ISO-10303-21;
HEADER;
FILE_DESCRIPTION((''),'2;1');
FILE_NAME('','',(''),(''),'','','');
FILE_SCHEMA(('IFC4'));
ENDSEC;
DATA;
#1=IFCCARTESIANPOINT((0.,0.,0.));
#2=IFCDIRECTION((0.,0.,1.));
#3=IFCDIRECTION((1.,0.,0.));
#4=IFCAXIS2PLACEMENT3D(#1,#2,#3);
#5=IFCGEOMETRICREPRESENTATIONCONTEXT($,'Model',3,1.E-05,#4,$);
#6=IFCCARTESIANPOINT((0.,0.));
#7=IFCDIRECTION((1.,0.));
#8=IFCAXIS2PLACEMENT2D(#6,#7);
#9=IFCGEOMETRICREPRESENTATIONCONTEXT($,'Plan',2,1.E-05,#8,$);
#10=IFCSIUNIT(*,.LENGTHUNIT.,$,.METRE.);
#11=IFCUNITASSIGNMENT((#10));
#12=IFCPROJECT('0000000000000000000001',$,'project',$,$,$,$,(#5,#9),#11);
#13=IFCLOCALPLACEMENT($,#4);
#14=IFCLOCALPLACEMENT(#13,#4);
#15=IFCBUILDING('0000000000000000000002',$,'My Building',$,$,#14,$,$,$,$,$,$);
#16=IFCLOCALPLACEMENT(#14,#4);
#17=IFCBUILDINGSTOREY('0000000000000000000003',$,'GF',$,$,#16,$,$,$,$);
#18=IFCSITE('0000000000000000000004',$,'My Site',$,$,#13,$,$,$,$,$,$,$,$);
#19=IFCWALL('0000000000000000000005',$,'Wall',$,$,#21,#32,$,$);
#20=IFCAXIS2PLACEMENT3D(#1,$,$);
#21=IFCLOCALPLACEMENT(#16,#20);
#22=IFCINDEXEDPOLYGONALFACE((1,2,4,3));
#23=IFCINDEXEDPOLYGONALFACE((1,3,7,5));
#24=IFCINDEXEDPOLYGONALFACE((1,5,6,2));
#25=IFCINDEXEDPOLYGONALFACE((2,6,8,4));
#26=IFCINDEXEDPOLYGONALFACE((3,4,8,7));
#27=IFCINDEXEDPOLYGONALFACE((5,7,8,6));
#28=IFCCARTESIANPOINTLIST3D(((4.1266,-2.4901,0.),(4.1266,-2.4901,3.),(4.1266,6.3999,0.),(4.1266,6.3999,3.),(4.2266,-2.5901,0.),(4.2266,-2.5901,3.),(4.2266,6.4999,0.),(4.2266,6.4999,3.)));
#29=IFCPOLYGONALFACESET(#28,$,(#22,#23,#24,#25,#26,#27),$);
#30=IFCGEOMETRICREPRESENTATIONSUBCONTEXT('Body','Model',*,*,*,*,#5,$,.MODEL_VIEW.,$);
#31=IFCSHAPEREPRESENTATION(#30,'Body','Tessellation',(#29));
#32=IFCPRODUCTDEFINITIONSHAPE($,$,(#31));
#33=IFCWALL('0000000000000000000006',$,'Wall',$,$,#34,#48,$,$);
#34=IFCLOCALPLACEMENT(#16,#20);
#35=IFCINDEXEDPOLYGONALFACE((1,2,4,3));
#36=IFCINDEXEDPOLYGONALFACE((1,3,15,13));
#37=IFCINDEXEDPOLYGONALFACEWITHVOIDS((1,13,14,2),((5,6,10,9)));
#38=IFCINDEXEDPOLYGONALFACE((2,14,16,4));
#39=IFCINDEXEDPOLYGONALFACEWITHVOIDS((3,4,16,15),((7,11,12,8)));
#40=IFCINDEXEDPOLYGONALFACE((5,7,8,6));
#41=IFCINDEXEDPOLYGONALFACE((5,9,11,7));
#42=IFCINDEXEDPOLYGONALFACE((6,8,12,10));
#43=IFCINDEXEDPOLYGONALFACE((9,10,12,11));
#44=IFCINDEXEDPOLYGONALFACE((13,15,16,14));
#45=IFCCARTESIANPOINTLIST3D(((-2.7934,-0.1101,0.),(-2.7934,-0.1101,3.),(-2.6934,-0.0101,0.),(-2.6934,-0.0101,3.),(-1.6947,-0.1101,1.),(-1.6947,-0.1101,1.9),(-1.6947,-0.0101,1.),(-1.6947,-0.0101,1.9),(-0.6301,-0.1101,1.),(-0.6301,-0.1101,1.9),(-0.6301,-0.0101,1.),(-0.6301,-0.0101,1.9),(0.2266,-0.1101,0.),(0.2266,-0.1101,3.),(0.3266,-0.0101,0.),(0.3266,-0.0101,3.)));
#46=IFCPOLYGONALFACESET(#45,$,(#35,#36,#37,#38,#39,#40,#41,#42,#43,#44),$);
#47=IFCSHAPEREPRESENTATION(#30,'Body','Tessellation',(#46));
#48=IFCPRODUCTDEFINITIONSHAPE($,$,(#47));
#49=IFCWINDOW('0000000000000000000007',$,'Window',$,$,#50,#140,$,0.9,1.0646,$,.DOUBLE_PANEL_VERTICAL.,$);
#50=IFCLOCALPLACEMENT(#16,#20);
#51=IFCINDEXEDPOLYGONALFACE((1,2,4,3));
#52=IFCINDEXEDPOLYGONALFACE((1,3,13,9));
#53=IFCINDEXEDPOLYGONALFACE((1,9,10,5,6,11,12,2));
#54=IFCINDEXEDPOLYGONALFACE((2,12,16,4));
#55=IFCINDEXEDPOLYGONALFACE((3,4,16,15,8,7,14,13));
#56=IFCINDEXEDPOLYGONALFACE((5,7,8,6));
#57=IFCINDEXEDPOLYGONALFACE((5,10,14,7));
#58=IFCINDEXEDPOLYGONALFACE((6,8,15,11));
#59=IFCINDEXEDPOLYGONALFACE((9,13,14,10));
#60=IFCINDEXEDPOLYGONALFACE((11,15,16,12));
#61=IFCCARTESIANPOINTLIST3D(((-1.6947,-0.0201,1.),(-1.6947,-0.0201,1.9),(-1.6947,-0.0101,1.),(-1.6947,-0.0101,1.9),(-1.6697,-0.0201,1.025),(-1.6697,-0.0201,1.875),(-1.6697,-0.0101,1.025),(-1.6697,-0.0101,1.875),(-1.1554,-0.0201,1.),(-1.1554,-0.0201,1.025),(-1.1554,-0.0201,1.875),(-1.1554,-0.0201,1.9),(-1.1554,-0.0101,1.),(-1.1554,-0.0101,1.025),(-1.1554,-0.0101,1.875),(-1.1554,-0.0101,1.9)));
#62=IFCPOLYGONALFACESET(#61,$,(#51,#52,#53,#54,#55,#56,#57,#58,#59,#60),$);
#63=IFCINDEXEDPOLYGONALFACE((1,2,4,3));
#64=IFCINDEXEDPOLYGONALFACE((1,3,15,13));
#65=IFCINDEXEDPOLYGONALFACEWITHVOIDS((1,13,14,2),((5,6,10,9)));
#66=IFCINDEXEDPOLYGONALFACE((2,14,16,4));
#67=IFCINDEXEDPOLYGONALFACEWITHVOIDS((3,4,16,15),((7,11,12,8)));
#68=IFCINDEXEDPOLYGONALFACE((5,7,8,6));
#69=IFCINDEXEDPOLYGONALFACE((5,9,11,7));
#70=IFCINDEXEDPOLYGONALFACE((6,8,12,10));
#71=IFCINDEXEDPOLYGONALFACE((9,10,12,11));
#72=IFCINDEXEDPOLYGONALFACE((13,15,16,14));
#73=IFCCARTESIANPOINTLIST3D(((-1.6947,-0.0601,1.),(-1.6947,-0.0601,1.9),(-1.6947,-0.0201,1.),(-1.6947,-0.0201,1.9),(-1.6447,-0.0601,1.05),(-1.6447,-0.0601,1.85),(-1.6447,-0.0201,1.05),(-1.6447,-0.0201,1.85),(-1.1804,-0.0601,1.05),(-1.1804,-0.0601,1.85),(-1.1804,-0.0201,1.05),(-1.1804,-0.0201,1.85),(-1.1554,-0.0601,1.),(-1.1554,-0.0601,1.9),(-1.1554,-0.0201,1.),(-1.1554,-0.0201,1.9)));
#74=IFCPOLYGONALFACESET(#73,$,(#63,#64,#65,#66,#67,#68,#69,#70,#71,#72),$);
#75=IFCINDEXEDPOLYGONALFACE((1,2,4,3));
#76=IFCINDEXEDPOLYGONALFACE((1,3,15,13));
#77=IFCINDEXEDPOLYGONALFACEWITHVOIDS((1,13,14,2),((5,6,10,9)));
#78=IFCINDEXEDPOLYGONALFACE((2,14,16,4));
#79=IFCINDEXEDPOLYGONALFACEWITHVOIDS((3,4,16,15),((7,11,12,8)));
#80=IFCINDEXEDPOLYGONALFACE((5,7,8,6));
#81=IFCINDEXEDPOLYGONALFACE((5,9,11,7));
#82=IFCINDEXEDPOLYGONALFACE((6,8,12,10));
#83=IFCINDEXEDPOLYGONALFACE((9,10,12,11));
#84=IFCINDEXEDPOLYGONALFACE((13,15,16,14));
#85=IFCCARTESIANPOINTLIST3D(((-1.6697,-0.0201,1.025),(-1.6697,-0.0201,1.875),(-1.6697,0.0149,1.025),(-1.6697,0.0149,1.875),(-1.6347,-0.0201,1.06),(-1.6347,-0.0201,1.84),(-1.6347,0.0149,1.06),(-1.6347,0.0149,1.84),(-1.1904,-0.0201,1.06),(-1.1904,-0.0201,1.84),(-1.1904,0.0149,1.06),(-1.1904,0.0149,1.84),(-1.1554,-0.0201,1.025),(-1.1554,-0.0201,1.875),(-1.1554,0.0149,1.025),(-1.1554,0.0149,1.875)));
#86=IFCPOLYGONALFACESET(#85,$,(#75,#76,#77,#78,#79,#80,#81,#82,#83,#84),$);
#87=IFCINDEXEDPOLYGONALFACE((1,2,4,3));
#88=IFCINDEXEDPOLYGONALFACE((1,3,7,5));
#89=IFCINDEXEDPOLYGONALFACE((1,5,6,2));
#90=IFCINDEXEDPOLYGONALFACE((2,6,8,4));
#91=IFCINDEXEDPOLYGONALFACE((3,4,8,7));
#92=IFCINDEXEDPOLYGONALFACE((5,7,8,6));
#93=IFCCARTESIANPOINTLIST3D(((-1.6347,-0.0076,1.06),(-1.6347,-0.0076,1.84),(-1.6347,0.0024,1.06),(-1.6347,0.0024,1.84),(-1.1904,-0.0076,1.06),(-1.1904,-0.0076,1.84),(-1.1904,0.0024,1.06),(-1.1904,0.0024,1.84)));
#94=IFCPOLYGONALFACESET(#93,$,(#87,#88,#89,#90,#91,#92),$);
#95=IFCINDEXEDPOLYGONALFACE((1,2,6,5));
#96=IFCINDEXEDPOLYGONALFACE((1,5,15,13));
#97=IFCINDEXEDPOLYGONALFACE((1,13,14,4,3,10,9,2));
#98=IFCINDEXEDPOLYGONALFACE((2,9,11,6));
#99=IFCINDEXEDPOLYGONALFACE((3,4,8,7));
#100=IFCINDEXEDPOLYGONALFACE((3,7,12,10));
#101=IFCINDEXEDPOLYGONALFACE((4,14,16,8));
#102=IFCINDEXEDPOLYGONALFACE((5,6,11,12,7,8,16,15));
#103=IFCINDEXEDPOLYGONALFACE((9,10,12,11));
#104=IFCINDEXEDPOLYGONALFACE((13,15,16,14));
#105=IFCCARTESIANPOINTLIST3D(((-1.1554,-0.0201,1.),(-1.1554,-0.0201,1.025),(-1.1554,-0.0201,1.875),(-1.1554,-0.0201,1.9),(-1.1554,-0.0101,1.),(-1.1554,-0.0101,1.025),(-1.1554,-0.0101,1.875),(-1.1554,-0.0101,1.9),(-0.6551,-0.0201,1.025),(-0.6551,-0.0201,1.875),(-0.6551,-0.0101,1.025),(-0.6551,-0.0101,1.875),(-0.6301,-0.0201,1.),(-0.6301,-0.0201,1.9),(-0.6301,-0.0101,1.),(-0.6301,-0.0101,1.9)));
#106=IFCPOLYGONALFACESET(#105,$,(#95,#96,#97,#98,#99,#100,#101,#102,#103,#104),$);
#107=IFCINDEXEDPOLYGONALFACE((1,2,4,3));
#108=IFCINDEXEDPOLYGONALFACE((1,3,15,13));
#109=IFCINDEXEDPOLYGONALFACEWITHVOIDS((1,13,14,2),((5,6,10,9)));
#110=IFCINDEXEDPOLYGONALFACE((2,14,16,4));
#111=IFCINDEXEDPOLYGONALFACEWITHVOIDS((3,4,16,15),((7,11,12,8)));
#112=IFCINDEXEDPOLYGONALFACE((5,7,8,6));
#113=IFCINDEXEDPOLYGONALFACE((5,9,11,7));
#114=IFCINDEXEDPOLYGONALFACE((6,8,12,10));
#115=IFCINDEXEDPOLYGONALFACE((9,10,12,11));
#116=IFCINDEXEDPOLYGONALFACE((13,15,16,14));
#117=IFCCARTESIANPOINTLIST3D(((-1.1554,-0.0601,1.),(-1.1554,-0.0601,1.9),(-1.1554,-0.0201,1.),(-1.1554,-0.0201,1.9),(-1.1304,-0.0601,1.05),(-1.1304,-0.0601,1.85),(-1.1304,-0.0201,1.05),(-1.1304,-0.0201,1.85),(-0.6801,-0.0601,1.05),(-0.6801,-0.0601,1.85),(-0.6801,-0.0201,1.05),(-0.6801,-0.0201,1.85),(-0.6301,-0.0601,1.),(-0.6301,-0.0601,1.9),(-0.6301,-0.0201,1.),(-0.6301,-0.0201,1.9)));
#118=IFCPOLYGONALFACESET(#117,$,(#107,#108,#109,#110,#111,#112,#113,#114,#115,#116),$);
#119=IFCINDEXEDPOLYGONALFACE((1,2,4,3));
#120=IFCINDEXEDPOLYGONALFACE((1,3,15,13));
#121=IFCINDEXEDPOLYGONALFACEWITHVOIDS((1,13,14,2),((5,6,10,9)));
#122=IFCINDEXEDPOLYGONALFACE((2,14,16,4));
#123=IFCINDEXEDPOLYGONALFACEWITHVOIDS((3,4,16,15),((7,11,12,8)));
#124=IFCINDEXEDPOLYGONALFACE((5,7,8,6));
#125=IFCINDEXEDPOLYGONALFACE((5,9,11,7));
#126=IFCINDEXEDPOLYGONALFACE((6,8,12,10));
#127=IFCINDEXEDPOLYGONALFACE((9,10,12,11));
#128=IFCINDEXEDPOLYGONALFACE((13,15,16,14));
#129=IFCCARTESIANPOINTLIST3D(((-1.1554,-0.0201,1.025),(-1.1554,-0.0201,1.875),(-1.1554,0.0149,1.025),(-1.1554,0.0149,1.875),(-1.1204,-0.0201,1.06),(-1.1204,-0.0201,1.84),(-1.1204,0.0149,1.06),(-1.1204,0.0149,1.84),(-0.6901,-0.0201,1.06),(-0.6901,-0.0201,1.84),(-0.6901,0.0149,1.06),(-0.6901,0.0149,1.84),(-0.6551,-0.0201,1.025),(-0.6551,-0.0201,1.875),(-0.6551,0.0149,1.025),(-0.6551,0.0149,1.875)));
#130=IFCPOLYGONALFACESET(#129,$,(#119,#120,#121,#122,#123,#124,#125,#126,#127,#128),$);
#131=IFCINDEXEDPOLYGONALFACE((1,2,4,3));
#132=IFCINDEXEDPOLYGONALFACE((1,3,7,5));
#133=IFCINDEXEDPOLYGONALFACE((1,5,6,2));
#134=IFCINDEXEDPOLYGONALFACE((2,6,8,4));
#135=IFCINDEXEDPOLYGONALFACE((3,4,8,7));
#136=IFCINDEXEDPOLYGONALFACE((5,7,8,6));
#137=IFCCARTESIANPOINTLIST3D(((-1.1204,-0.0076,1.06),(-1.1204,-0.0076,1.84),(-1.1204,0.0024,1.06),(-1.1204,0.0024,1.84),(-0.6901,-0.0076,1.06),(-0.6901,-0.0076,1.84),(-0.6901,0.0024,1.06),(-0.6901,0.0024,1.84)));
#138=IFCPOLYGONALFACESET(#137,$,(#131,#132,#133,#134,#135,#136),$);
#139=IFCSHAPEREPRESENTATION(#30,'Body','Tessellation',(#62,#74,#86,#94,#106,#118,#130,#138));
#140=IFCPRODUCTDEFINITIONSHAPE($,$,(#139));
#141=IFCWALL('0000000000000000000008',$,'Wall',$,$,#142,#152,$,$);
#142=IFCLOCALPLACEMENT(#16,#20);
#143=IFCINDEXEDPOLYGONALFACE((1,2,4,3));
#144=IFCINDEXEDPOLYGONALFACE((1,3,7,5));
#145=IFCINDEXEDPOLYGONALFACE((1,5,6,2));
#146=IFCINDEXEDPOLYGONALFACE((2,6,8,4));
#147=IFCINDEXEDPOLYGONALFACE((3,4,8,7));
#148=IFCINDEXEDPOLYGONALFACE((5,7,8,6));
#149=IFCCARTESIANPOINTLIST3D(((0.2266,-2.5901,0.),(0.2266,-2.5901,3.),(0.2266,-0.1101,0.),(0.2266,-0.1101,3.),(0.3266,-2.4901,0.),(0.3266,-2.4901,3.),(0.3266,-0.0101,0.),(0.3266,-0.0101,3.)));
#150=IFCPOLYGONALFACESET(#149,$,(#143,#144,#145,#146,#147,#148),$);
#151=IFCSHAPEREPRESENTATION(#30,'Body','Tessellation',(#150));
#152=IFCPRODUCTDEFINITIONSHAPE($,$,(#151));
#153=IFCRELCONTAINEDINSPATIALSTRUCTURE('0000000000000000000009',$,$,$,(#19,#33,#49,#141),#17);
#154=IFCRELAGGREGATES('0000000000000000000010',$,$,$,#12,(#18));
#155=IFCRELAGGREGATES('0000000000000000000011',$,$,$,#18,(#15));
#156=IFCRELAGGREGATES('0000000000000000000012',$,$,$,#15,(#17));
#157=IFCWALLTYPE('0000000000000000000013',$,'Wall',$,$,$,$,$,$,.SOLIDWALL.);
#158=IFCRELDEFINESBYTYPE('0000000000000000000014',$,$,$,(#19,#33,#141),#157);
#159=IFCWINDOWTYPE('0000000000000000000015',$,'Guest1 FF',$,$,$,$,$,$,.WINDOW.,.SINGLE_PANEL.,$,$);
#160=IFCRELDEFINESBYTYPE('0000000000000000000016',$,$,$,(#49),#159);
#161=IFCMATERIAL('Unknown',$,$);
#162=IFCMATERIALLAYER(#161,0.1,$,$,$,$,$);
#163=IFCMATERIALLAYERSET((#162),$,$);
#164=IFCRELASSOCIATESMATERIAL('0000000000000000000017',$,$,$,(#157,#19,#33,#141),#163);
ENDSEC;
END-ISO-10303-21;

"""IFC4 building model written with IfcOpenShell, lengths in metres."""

from ifc_helpers import new_model, entity, si_unit, frame, origin_with_axes, origin_2d_with_axis, place, context, subcontext, project, spatial, line, indexed_curve, outline, extrude, shape, source, transform, mapped, material, layer, layer_set, layer_usage, type_object, type_shapes, element, fill, save


model = new_model("IFC4")

# Units and contexts
model_context = context("Model", 3, precision=1e-05, world=origin_with_axes())
plan_context = context("Plan", 2, precision=1e-05, world=origin_2d_with_axis())
body_context_1 = subcontext(model_context, "Body", "Model", "MODEL_VIEW")
body_context_2 = subcontext(plan_context, "Body", "Plan", "PLAN_VIEW")
ifc_project = project(units=[si_unit("LENGTHUNIT", "METRE")], contexts=[model_context, plan_context])

# Site, building, storey
site_placement = place(None, origin_with_axes())
site = spatial("IfcSite", under=ifc_project, at=site_placement, Name="My Site")
building_placement = place(site_placement, origin_with_axes())
building = spatial("IfcBuilding", under=site, at=building_placement, Name="My Building")
storey_placement = place(building_placement, origin_with_axes())
storey = spatial("IfcBuildingStorey", under=building, at=storey_placement, Name="GF")

# Shared definitions
ifc_material = material(Name="Unknown")

# Shared definitions
ifc_layer_1 = layer(ifc_material, 0.1)
ifc_layer_set_1 = layer_set([ifc_layer_1])
wall_type = type_object("IfcWallType", Name="Wall", PredefinedType="SOLIDWALL", material=ifc_layer_set_1)

# Wall
ifc_layer_usage_1 = layer_usage(ifc_layer_set_1, "AXIS2", "POSITIVE", 0.0)
wall_1_placement = place(storey_placement, frame((4.2266, -2.5901, 0.0), z_axis=(0.0, 0.0, 1.0), x_axis=(0.0, 1.0, 0.0)))
element("IfcWall", 1, at=wall_1_placement, inside=storey, type_object=wall_type, material=ifc_layer_usage_1, Name="Wall", context=body_context_1, shape_type="SweptSolid", body=[
    extrude(outline(indexed_curve([(0.0, 0.0), (0.1, 0.1), (8.99, 0.1), (9.09, 0.0)], segments=[line(1, 2, 3, 4, 1)])), origin_with_axes(), (0.0, 0.0, 1.0), 3.0),
])

# Wall, opening, window
ifc_layer_usage_2 = layer_usage(ifc_layer_set_1, "AXIS2", "POSITIVE", 0.0)
wall_2_placement = place(storey_placement, frame((-2.7934, -0.1101, 0.0), z_axis=(0.0, 0.0, 1.0), x_axis=(1.0, 0.0, 0.0)))
wall_2 = element("IfcWall", 2, at=wall_2_placement, inside=storey, type_object=wall_type, material=ifc_layer_usage_2, Name="Wall", context=body_context_1, shape_type="SweptSolid", body=[
    extrude(outline(indexed_curve([(0.0, 0.0), (0.1, 0.1), (3.12, 0.1), (3.02, 0.0)], segments=[line(1, 2, 3, 4, 1)])), origin_with_axes(), (0.0, 0.0, 1.0), 3.0),
])
shared_shape_1 = source(origin_with_axes(), body_context_1, "Body", "SweptSolid", [
    extrude(outline(indexed_curve([(0.0, 0.0), (1.0646, 0.0), (1.0646, 0.9), (0.0, 0.9)], segments=[line(1, 2, 3, 4, 1)])), frame((0.0, -0.6, 0.0), z_axis=(0.0, -1.0, 0.0), x_axis=(1.0, 0.0, 0.0)), (0.0, 0.0, -1.0), 1.2),
])
opening_1_placement = place(wall_2_placement, frame((1.0987, 0.0, 1.0), z_axis=(0.0, 0.0, 1.0), x_axis=(1.0, 0.0, 0.0)))
opening_1 = element("IfcOpeningElement", 3, at=opening_1_placement, cuts=wall_2, PredefinedType="OPENING", context=body_context_1, shape_type="MappedRepresentation", body=[
    mapped(shared_shape_1, transform((0.0, 0.0, 0.0), x_axis=(1.0, 0.0, 0.0), y_axis=(0.0, 1.0, 0.0), z_axis=(0.0, 0.0, 1.0), scale=1.0)),
])
window_type_1 = type_object("IfcWindowType", Name="Guest1 FF", PartitioningType="SINGLE_PANEL", PredefinedType="WINDOW")
shared_shape_2 = source(origin_with_axes(), body_context_1, "Body", "SweptSolid", [
    extrude(outline(indexed_curve([(0.5393, 0.0), (0.0, 0.0), (0.0, 0.9), (0.5393, 0.9), (0.5393, 0.875), (0.025, 0.875), (0.025, 0.025), (0.5393, 0.025)], segments=[line(1, 2, 3, 4, 5, 6, 7, 8, 1)])), frame((0.0, 0.09, 0.0), z_axis=(0.0, -1.0, 0.0), x_axis=(1.0, 0.0, 0.0)), (0.0, 0.0, -1.0), 0.01),
    extrude(outline(indexed_curve([(0.0, 0.0), (0.5393, 0.0), (0.5393, 0.9), (0.0, 0.9)], segments=[line(1, 2, 3, 4, 1)]), holes=[indexed_curve([(0.05, 0.05), (0.5143, 0.05), (0.5143, 0.85), (0.05, 0.85)], segments=[line(1, 2, 3, 4, 1)])]), frame((0.0, 0.05, 0.0), z_axis=(0.0, -1.0, 0.0), x_axis=(1.0, 0.0, 0.0)), (0.0, 0.0, -1.0), 0.04),
    extrude(outline(indexed_curve([(0.0, 0.0), (0.5143, 0.0), (0.5143, 0.85), (0.0, 0.85)], segments=[line(1, 2, 3, 4, 1)]), holes=[indexed_curve([(0.035, 0.035), (0.4793, 0.035), (0.4793, 0.815), (0.035, 0.815)], segments=[line(1, 2, 3, 4, 1)])]), frame((0.025, 0.09, 0.025), z_axis=(0.0, -1.0, 0.0), x_axis=(1.0, 0.0, 0.0)), (0.0, 0.0, -1.0), 0.035),
    extrude(outline(indexed_curve([(0.035, 0.035), (0.4793, 0.035), (0.4793, 0.815), (0.035, 0.815)], segments=[line(1, 2, 3, 4, 1)])), frame((0.025, 0.1025, 0.025), z_axis=(0.0, -1.0, 0.0), x_axis=(1.0, 0.0, 0.0)), (0.0, 0.0, -1.0), 0.01),
    extrude(outline(indexed_curve([(0.0, 0.9), (0.5253, 0.9), (0.5253, 0.0), (0.0, 0.0), (0.0, 0.025), (0.5003, 0.025), (0.5003, 0.875), (0.0, 0.875)], segments=[line(1, 2, 3, 4, 5, 6, 7, 8, 1)])), frame((0.5393, 0.09, 0.0), z_axis=(0.0, -1.0, 0.0), x_axis=(1.0, 0.0, 0.0)), (0.0, 0.0, -1.0), 0.01),
    extrude(outline(indexed_curve([(0.0, 0.0), (0.5253, 0.0), (0.5253, 0.9), (0.0, 0.9)], segments=[line(1, 2, 3, 4, 1)]), holes=[indexed_curve([(0.025, 0.05), (0.4753, 0.05), (0.4753, 0.85), (0.025, 0.85)], segments=[line(1, 2, 3, 4, 1)])]), frame((0.5393, 0.05, 0.0), z_axis=(0.0, -1.0, 0.0), x_axis=(1.0, 0.0, 0.0)), (0.0, 0.0, -1.0), 0.04),
    extrude(outline(indexed_curve([(0.0, 0.0), (0.5003, 0.0), (0.5003, 0.85), (0.0, 0.85)], segments=[line(1, 2, 3, 4, 1)]), holes=[indexed_curve([(0.035, 0.035), (0.4653, 0.035), (0.4653, 0.815), (0.035, 0.815)], segments=[line(1, 2, 3, 4, 1)])]), frame((0.5393, 0.09, 0.025), z_axis=(0.0, -1.0, 0.0), x_axis=(1.0, 0.0, 0.0)), (0.0, 0.0, -1.0), 0.035),
    extrude(outline(indexed_curve([(0.035, 0.035), (0.4653, 0.035), (0.4653, 0.815), (0.035, 0.815)], segments=[line(1, 2, 3, 4, 1)])), frame((0.5393, 0.1025, 0.025), z_axis=(0.0, -1.0, 0.0), x_axis=(1.0, 0.0, 0.0)), (0.0, 0.0, -1.0), 0.01),
])
shared_shape_3 = source(origin_with_axes(), body_context_2, "Body", "Curve2D", [
    entity("IfcIndexedPolyCurve", entity("IfcCartesianPointList2D", [[0.05, 0.05], [0.5143, 0.05]])),
    entity("IfcIndexedPolyCurve", entity("IfcCartesianPointList2D", [[0.0, 0.1], [0.025, 0.1], [0.025, 0.09], [0.05, 0.09], [0.05, 0.05], [0.0, 0.05]]), [entity("IfcLineIndex", [1, 2, 3, 4, 5, 6, 1])]),
    entity("IfcIndexedPolyCurve", entity("IfcCartesianPointList2D", [[0.5393, 0.1], [0.5393, 0.1], [0.5393, 0.09], [0.5143, 0.09], [0.5143, 0.05], [0.5393, 0.05]])),
    entity("IfcIndexedPolyCurve", entity("IfcCartesianPointList2D", [[0.025, 0.09], [0.06, 0.09], [0.06, 0.125], [0.025, 0.125]]), [entity("IfcLineIndex", [1, 2, 3, 4, 1])]),
    entity("IfcIndexedPolyCurve", entity("IfcCartesianPointList2D", [[0.5393, 0.09], [0.5043, 0.09], [0.5043, 0.125], [0.5393, 0.125]]), [entity("IfcLineIndex", [1, 2, 3, 4, 1])]),
    entity("IfcIndexedPolyCurve", entity("IfcCartesianPointList2D", [[0.06, 0.09], [0.5043, 0.09]])),
    entity("IfcIndexedPolyCurve", entity("IfcCartesianPointList2D", [[0.06, 0.125], [0.5043, 0.125]])),
    entity("IfcIndexedPolyCurve", entity("IfcCartesianPointList2D", [[0.06, 0.1075], [0.5043, 0.1075]])),
    entity("IfcIndexedPolyCurve", entity("IfcCartesianPointList2D", [[0.5643, 0.05], [1.0146, 0.05]])),
    entity("IfcIndexedPolyCurve", entity("IfcCartesianPointList2D", [[0.5393, 0.1], [0.5393, 0.1], [0.5393, 0.09], [0.5643, 0.09], [0.5643, 0.05], [0.5393, 0.05]])),
    entity("IfcIndexedPolyCurve", entity("IfcCartesianPointList2D", [[1.0646, 0.1], [1.0396, 0.1], [1.0396, 0.09], [1.0146, 0.09], [1.0146, 0.05], [1.0646, 0.05]]), [entity("IfcLineIndex", [1, 2, 3, 4, 5, 6, 1])]),
    entity("IfcIndexedPolyCurve", entity("IfcCartesianPointList2D", [[0.5393, 0.09], [0.5743, 0.09], [0.5743, 0.125], [0.5393, 0.125]]), [entity("IfcLineIndex", [1, 2, 3, 4, 1])]),
    entity("IfcIndexedPolyCurve", entity("IfcCartesianPointList2D", [[1.0396, 0.09], [1.0046, 0.09], [1.0046, 0.125], [1.0396, 0.125]]), [entity("IfcLineIndex", [1, 2, 3, 4, 1])]),
    entity("IfcIndexedPolyCurve", entity("IfcCartesianPointList2D", [[0.5743, 0.09], [1.0046, 0.09]])),
    entity("IfcIndexedPolyCurve", entity("IfcCartesianPointList2D", [[0.5743, 0.125], [1.0046, 0.125]])),
    entity("IfcIndexedPolyCurve", entity("IfcCartesianPointList2D", [[0.5743, 0.1075], [1.0046, 0.1075]])),
])
type_shapes(window_type_1, [shared_shape_2, shared_shape_3])
window_1_placement = place(opening_1_placement, origin_with_axes())
window_1 = element("IfcWindow", 4, at=window_1_placement, inside=storey, type_object=window_type_1, Name="Window", OverallHeight=0.9, OverallWidth=1.0646, PartitioningType="DOUBLE_PANEL_VERTICAL", shapes=[
    shape(body_context_1, "Body", "MappedRepresentation", [mapped(shared_shape_2, transform((0.0, 0.0, 0.0), x_axis=(1.0, 0.0, 0.0), y_axis=(0.0, 1.0, 0.0), z_axis=(0.0, 0.0, 1.0), scale=1.0))]),
    shape(body_context_2, "Body", "MappedRepresentation", [mapped(shared_shape_3, transform((0.0, 0.0, 0.0), x_axis=(1.0, 0.0, 0.0), y_axis=(0.0, 1.0, 0.0), z_axis=(0.0, 0.0, 1.0), scale=1.0))]),
])
fill(opening_1, window_1)

# Wall
ifc_layer_usage_3 = layer_usage(ifc_layer_set_1, "AXIS2", "POSITIVE", 0.0)
wall_3_placement = place(storey_placement, frame((0.2266, -0.1101, 0.0), z_axis=(0.0, 0.0, 1.0), x_axis=(0.0, -1.0, 0.0)))
element("IfcWall", 5, at=wall_3_placement, inside=storey, type_object=wall_type, material=ifc_layer_usage_3, Name="Wall", context=body_context_1, shape_type="SweptSolid", body=[
    extrude(outline(indexed_curve([(0.0, 0.0), (-0.1, 0.1), (2.38, 0.1), (2.48, 0.0)], segments=[line(1, 2, 3, 4, 1)])), origin_with_axes(), (0.0, 0.0, 1.0), 3.0),
])

save(model, "model.ifc")
